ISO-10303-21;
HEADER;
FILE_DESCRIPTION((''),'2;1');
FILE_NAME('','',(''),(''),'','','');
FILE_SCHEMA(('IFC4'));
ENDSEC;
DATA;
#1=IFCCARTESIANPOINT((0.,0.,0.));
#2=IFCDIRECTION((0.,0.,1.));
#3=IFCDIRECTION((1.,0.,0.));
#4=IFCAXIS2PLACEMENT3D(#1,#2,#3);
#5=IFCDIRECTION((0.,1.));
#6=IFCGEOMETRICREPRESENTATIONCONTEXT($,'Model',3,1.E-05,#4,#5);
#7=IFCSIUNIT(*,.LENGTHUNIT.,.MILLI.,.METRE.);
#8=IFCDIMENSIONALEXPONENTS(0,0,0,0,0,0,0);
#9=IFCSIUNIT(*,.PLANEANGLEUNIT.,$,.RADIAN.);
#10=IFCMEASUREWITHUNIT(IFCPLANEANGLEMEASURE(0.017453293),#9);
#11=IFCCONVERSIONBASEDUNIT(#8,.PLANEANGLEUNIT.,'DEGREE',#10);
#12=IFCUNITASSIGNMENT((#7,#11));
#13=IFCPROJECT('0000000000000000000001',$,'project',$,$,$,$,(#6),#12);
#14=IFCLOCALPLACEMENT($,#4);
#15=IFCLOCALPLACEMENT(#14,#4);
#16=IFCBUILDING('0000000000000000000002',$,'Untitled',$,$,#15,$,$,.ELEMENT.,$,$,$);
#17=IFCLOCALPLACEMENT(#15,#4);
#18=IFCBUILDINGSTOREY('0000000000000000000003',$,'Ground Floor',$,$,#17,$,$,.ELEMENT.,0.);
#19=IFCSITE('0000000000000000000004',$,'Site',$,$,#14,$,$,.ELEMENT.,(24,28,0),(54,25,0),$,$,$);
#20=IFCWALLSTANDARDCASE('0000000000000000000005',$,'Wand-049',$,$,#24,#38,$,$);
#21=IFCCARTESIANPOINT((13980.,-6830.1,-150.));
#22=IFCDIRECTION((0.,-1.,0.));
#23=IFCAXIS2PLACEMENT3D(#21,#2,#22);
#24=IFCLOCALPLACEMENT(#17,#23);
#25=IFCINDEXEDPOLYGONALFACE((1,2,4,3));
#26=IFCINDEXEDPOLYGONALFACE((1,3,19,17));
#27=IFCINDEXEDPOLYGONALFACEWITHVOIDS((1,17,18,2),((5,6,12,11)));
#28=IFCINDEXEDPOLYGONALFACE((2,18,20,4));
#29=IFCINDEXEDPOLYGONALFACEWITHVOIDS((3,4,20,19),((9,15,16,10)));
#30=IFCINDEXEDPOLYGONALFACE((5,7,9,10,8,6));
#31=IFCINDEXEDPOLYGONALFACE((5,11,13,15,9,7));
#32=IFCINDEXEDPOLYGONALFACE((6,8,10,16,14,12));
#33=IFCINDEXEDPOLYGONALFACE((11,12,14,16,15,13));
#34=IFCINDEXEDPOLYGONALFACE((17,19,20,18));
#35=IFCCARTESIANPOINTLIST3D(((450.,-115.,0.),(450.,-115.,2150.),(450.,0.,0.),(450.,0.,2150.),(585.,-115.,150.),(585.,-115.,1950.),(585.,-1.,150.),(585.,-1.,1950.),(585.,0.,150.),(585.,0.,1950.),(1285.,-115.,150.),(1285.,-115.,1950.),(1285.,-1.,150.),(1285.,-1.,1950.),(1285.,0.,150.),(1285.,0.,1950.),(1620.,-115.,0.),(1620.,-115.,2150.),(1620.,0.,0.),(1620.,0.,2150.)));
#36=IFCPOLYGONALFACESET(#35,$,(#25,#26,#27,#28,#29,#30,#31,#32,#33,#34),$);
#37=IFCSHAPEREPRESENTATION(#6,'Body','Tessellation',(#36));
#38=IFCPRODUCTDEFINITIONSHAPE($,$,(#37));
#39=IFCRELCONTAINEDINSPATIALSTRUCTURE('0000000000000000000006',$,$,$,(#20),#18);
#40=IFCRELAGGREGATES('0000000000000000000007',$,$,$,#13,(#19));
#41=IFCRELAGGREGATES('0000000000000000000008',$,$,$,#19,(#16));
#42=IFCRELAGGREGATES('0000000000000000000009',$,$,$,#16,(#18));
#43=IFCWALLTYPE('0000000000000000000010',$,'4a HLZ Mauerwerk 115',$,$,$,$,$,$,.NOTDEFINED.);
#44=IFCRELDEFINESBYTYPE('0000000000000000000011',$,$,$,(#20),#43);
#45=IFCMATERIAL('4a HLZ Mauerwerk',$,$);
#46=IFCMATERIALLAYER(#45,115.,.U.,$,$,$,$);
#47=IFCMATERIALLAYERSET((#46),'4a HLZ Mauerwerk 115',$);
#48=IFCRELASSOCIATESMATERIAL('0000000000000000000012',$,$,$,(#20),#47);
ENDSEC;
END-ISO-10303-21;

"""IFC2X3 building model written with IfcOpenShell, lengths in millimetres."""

from ifc_helpers import new_model, entity, si_unit, converted_unit, direction, frame, origin_with_axes, origin_2d_with_axis, place, context, project, spatial, polyline, rectangle, outline, extrude, material, layer, layer_set, layer_usage, type_object, element, save


model = new_model("IFC2X3")

# Units and contexts
model_context = context("Model", 3, precision=1e-05, world=origin_with_axes(), true_north=direction((0.0, 1.0)))
ifc_project = project(units=[si_unit("LENGTHUNIT", "METRE", prefix="MILLI"), converted_unit("PLANEANGLEUNIT", "DEGREE", entity("IfcPlaneAngleMeasure", 0.017453293), si_unit("PLANEANGLEUNIT", "RADIAN"), dimensions=[0, 0, 0, 0, 0, 0, 0])], contexts=[model_context])

# Site, building, storey
site_placement = place(None, origin_with_axes())
site = spatial("IfcSite", under=ifc_project, at=site_placement, Name="Site", CompositionType="ELEMENT", RefLatitude=(24, 28, 0), RefLongitude=(54, 25, 0))
building_placement = place(site_placement, origin_with_axes())
building = spatial("IfcBuilding", under=site, at=building_placement, Name="Untitled", CompositionType="ELEMENT")
storey_placement = place(building_placement, origin_with_axes())
storey = spatial("IfcBuildingStorey", under=building, at=storey_placement, Name="Ground Floor", CompositionType="ELEMENT", Elevation=0.0)

# Shared definitions
ifc_material_1 = material(Name="4a HLZ Mauerwerk")

# Shared definitions
ifc_layer_1 = layer(ifc_material_1, 115.0, ventilated="UNKNOWN")
ifc_layer_set_1 = layer_set([ifc_layer_1], Name="4a HLZ Mauerwerk 115")
wall_type_1 = type_object("IfcWallType", Name="4a HLZ Mauerwerk 115", PredefinedType="NOTDEFINED")

# Wall, opening
ifc_layer_usage_1 = layer_usage(ifc_layer_set_1, "AXIS2", "NEGATIVE", 0.0)
wall_1_placement = place(storey_placement, frame((13980.0, -6830.1, -150.0), z_axis=(0.0, 0.0, 1.0), x_axis=(0.0, -1.0, 0.0)))
wall_1 = element("IfcWallStandardCase", 1, at=wall_1_placement, inside=storey, type_object=wall_type_1, material=ifc_layer_usage_1, Name="Wand-049", context=model_context, shape_type="SweptSolid", body=[
    extrude(outline(polyline([(450.0, -115.0), (1620.0, -115.0), (1620.0, 0.0), (450.0, 0.0), (450.0, -115.0)])), origin_with_axes(), (0.0, 0.0, 1.0), 2150.0),
])
opening_1_placement = place(wall_1_placement, frame((935.0, 0.0, 150.0), z_axis=(0.0, 0.0, 1.0), x_axis=(1.0, 0.0, 0.0)))
element("IfcOpeningElement", 2, at=opening_1_placement, cuts=wall_1, context=model_context, shape_type="SweptSolid", body=[
    extrude(rectangle(XDim=700.0, YDim=1800.0, at=origin_2d_with_axis()), frame((0.0, 231.0, 900.0), z_axis=(0.0, -1.0, 0.0), x_axis=(1.0, 0.0, 0.0)), (0.0, 0.0, 1.0), 232.0),
    extrude(rectangle(XDim=700.0, YDim=1800.0, at=origin_2d_with_axis()), frame((0.0, -231.0, 900.0), z_axis=(0.0, 1.0, 0.0), x_axis=(1.0, 0.0, 0.0)), (0.0, 0.0, 1.0), 232.0),
])

save(model, "model.ifc")
